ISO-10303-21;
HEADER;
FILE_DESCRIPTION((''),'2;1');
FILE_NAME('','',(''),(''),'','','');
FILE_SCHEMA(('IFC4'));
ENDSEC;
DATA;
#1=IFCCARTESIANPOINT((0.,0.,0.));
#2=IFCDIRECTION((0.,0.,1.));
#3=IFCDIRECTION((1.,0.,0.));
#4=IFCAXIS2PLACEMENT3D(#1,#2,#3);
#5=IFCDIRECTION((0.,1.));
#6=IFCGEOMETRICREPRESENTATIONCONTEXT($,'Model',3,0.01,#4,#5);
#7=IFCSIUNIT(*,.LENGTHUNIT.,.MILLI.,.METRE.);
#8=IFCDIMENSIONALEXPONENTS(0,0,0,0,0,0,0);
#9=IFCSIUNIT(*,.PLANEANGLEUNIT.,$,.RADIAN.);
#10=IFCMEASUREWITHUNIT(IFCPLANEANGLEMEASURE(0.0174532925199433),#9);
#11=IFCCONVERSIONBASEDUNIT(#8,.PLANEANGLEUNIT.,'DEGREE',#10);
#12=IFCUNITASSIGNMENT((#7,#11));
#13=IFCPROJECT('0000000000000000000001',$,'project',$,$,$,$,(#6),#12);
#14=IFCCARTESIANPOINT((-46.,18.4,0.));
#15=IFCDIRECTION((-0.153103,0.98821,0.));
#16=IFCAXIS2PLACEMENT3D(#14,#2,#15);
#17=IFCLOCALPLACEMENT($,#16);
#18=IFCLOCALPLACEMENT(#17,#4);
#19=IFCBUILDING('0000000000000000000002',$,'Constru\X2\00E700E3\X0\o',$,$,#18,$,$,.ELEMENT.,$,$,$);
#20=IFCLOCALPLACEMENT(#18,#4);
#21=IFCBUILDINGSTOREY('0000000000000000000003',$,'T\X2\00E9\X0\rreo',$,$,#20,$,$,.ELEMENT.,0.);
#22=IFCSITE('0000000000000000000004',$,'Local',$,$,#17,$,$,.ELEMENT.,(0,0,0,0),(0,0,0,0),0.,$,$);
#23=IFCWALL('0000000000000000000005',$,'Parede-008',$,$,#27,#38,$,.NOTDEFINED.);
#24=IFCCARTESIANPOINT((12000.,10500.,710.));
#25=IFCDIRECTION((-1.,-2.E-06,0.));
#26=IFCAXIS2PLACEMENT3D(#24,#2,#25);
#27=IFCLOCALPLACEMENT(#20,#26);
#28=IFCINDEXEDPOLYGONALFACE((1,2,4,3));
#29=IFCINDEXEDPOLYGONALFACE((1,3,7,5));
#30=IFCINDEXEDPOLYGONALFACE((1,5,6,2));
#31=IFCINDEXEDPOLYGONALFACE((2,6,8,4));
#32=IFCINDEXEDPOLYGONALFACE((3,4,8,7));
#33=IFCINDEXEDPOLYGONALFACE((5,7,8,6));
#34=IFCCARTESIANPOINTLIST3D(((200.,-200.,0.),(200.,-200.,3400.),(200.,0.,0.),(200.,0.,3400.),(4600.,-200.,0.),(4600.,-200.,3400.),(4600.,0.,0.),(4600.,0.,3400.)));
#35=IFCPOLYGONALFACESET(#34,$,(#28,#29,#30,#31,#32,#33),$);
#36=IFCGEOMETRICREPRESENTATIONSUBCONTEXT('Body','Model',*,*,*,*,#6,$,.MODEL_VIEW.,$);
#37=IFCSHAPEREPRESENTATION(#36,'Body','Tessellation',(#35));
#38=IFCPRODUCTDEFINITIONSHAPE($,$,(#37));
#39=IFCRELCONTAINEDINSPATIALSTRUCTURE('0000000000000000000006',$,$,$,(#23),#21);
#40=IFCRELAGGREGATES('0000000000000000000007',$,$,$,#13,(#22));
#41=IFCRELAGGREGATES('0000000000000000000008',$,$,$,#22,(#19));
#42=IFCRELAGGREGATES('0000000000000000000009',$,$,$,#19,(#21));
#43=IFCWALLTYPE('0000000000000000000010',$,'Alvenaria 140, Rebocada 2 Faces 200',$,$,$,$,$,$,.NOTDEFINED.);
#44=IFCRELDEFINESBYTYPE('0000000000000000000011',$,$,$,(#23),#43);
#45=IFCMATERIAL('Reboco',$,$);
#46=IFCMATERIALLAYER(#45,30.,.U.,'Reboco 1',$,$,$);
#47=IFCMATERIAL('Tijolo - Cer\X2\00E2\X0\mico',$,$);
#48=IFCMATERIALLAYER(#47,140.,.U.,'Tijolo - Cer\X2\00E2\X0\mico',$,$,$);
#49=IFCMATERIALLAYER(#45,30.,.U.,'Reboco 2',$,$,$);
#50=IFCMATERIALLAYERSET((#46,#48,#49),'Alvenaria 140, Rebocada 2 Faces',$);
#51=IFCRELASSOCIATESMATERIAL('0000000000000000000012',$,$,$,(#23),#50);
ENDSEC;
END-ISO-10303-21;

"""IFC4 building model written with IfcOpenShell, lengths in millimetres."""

from ifc_helpers import new_model, entity, si_unit, converted_unit, direction, frame, origin_with_axes, place, context, subcontext, project, spatial, line, indexed_curve, outline, extrude, material, layer, layer_set, layer_usage, type_object, element, save


model = new_model("IFC4")

# Units and contexts
model_context = context("Model", 3, precision=0.01, world=origin_with_axes(), true_north=direction((0.0, 1.0)))
body_context = subcontext(model_context, "Body", "Model", "MODEL_VIEW")
ifc_project = project(units=[si_unit("LENGTHUNIT", "METRE", prefix="MILLI"), converted_unit("PLANEANGLEUNIT", "DEGREE", entity("IfcPlaneAngleMeasure", 0.0174532925199433), si_unit("PLANEANGLEUNIT", "RADIAN"), dimensions=[0, 0, 0, 0, 0, 0, 0])], contexts=[model_context])

# Site, building, storey
site_placement = place(None, frame((-46.0, 18.4, 0.0), z_axis=(0.0, 0.0, 1.0), x_axis=(-0.153103, 0.98821, 0.0)))
site = spatial("IfcSite", under=ifc_project, at=site_placement, Name="Local", CompositionType="ELEMENT", RefLatitude=(0, 0, 0, 0), RefLongitude=(0, 0, 0, 0), RefElevation=0.0)
building_placement = place(site_placement, origin_with_axes())
building = spatial("IfcBuilding", under=site, at=building_placement, Name="Construção", CompositionType="ELEMENT")
storey_placement = place(building_placement, origin_with_axes())
storey = spatial("IfcBuildingStorey", under=building, at=storey_placement, Name="Térreo", CompositionType="ELEMENT", Elevation=0.0)

# Shared definitions
ifc_material_1 = material(Name="Reboco")
ifc_layer_1 = layer(ifc_material_1, 30.0, ventilated="UNKNOWN", Name="Reboco 1")
ifc_material_2 = material(Name="Tijolo - Cerâmico")
ifc_layer_2 = layer(ifc_material_2, 140.0, ventilated="UNKNOWN", Name="Tijolo - Cerâmico")
ifc_layer_3 = layer(ifc_material_1, 30.0, ventilated="UNKNOWN", Name="Reboco 2")
ifc_layer_set_1 = layer_set([ifc_layer_1, ifc_layer_2, ifc_layer_3], Name="Alvenaria 140, Rebocada 2 Faces")
wall_type_1 = type_object("IfcWallType", Name="Alvenaria 140, Rebocada 2 Faces 200", PredefinedType="NOTDEFINED")

# Wall
ifc_layer_usage_1 = layer_usage(ifc_layer_set_1, "AXIS2", "NEGATIVE", 0.0)
wall_1_placement = place(storey_placement, frame((12000.0, 10500.0, 710.0), z_axis=(0.0, 0.0, 1.0), x_axis=(-1.0, -0.000002, 0.0)))
element("IfcWall", 1, at=wall_1_placement, inside=storey, type_object=wall_type_1, material=ifc_layer_usage_1, Name="Parede-008", PredefinedType="NOTDEFINED", context=body_context, shape_type="SweptSolid", body=[
    extrude(outline(indexed_curve([(200.0, -200.0), (4600.0, -200.0), (4600.0, 0.0), (200.0, 0.0)], segments=[line(1, 2, 3, 4, 1)])), origin_with_axes(), (0.0, 0.0, 1.0), 3400.0),
])

save(model, "model.ifc")
